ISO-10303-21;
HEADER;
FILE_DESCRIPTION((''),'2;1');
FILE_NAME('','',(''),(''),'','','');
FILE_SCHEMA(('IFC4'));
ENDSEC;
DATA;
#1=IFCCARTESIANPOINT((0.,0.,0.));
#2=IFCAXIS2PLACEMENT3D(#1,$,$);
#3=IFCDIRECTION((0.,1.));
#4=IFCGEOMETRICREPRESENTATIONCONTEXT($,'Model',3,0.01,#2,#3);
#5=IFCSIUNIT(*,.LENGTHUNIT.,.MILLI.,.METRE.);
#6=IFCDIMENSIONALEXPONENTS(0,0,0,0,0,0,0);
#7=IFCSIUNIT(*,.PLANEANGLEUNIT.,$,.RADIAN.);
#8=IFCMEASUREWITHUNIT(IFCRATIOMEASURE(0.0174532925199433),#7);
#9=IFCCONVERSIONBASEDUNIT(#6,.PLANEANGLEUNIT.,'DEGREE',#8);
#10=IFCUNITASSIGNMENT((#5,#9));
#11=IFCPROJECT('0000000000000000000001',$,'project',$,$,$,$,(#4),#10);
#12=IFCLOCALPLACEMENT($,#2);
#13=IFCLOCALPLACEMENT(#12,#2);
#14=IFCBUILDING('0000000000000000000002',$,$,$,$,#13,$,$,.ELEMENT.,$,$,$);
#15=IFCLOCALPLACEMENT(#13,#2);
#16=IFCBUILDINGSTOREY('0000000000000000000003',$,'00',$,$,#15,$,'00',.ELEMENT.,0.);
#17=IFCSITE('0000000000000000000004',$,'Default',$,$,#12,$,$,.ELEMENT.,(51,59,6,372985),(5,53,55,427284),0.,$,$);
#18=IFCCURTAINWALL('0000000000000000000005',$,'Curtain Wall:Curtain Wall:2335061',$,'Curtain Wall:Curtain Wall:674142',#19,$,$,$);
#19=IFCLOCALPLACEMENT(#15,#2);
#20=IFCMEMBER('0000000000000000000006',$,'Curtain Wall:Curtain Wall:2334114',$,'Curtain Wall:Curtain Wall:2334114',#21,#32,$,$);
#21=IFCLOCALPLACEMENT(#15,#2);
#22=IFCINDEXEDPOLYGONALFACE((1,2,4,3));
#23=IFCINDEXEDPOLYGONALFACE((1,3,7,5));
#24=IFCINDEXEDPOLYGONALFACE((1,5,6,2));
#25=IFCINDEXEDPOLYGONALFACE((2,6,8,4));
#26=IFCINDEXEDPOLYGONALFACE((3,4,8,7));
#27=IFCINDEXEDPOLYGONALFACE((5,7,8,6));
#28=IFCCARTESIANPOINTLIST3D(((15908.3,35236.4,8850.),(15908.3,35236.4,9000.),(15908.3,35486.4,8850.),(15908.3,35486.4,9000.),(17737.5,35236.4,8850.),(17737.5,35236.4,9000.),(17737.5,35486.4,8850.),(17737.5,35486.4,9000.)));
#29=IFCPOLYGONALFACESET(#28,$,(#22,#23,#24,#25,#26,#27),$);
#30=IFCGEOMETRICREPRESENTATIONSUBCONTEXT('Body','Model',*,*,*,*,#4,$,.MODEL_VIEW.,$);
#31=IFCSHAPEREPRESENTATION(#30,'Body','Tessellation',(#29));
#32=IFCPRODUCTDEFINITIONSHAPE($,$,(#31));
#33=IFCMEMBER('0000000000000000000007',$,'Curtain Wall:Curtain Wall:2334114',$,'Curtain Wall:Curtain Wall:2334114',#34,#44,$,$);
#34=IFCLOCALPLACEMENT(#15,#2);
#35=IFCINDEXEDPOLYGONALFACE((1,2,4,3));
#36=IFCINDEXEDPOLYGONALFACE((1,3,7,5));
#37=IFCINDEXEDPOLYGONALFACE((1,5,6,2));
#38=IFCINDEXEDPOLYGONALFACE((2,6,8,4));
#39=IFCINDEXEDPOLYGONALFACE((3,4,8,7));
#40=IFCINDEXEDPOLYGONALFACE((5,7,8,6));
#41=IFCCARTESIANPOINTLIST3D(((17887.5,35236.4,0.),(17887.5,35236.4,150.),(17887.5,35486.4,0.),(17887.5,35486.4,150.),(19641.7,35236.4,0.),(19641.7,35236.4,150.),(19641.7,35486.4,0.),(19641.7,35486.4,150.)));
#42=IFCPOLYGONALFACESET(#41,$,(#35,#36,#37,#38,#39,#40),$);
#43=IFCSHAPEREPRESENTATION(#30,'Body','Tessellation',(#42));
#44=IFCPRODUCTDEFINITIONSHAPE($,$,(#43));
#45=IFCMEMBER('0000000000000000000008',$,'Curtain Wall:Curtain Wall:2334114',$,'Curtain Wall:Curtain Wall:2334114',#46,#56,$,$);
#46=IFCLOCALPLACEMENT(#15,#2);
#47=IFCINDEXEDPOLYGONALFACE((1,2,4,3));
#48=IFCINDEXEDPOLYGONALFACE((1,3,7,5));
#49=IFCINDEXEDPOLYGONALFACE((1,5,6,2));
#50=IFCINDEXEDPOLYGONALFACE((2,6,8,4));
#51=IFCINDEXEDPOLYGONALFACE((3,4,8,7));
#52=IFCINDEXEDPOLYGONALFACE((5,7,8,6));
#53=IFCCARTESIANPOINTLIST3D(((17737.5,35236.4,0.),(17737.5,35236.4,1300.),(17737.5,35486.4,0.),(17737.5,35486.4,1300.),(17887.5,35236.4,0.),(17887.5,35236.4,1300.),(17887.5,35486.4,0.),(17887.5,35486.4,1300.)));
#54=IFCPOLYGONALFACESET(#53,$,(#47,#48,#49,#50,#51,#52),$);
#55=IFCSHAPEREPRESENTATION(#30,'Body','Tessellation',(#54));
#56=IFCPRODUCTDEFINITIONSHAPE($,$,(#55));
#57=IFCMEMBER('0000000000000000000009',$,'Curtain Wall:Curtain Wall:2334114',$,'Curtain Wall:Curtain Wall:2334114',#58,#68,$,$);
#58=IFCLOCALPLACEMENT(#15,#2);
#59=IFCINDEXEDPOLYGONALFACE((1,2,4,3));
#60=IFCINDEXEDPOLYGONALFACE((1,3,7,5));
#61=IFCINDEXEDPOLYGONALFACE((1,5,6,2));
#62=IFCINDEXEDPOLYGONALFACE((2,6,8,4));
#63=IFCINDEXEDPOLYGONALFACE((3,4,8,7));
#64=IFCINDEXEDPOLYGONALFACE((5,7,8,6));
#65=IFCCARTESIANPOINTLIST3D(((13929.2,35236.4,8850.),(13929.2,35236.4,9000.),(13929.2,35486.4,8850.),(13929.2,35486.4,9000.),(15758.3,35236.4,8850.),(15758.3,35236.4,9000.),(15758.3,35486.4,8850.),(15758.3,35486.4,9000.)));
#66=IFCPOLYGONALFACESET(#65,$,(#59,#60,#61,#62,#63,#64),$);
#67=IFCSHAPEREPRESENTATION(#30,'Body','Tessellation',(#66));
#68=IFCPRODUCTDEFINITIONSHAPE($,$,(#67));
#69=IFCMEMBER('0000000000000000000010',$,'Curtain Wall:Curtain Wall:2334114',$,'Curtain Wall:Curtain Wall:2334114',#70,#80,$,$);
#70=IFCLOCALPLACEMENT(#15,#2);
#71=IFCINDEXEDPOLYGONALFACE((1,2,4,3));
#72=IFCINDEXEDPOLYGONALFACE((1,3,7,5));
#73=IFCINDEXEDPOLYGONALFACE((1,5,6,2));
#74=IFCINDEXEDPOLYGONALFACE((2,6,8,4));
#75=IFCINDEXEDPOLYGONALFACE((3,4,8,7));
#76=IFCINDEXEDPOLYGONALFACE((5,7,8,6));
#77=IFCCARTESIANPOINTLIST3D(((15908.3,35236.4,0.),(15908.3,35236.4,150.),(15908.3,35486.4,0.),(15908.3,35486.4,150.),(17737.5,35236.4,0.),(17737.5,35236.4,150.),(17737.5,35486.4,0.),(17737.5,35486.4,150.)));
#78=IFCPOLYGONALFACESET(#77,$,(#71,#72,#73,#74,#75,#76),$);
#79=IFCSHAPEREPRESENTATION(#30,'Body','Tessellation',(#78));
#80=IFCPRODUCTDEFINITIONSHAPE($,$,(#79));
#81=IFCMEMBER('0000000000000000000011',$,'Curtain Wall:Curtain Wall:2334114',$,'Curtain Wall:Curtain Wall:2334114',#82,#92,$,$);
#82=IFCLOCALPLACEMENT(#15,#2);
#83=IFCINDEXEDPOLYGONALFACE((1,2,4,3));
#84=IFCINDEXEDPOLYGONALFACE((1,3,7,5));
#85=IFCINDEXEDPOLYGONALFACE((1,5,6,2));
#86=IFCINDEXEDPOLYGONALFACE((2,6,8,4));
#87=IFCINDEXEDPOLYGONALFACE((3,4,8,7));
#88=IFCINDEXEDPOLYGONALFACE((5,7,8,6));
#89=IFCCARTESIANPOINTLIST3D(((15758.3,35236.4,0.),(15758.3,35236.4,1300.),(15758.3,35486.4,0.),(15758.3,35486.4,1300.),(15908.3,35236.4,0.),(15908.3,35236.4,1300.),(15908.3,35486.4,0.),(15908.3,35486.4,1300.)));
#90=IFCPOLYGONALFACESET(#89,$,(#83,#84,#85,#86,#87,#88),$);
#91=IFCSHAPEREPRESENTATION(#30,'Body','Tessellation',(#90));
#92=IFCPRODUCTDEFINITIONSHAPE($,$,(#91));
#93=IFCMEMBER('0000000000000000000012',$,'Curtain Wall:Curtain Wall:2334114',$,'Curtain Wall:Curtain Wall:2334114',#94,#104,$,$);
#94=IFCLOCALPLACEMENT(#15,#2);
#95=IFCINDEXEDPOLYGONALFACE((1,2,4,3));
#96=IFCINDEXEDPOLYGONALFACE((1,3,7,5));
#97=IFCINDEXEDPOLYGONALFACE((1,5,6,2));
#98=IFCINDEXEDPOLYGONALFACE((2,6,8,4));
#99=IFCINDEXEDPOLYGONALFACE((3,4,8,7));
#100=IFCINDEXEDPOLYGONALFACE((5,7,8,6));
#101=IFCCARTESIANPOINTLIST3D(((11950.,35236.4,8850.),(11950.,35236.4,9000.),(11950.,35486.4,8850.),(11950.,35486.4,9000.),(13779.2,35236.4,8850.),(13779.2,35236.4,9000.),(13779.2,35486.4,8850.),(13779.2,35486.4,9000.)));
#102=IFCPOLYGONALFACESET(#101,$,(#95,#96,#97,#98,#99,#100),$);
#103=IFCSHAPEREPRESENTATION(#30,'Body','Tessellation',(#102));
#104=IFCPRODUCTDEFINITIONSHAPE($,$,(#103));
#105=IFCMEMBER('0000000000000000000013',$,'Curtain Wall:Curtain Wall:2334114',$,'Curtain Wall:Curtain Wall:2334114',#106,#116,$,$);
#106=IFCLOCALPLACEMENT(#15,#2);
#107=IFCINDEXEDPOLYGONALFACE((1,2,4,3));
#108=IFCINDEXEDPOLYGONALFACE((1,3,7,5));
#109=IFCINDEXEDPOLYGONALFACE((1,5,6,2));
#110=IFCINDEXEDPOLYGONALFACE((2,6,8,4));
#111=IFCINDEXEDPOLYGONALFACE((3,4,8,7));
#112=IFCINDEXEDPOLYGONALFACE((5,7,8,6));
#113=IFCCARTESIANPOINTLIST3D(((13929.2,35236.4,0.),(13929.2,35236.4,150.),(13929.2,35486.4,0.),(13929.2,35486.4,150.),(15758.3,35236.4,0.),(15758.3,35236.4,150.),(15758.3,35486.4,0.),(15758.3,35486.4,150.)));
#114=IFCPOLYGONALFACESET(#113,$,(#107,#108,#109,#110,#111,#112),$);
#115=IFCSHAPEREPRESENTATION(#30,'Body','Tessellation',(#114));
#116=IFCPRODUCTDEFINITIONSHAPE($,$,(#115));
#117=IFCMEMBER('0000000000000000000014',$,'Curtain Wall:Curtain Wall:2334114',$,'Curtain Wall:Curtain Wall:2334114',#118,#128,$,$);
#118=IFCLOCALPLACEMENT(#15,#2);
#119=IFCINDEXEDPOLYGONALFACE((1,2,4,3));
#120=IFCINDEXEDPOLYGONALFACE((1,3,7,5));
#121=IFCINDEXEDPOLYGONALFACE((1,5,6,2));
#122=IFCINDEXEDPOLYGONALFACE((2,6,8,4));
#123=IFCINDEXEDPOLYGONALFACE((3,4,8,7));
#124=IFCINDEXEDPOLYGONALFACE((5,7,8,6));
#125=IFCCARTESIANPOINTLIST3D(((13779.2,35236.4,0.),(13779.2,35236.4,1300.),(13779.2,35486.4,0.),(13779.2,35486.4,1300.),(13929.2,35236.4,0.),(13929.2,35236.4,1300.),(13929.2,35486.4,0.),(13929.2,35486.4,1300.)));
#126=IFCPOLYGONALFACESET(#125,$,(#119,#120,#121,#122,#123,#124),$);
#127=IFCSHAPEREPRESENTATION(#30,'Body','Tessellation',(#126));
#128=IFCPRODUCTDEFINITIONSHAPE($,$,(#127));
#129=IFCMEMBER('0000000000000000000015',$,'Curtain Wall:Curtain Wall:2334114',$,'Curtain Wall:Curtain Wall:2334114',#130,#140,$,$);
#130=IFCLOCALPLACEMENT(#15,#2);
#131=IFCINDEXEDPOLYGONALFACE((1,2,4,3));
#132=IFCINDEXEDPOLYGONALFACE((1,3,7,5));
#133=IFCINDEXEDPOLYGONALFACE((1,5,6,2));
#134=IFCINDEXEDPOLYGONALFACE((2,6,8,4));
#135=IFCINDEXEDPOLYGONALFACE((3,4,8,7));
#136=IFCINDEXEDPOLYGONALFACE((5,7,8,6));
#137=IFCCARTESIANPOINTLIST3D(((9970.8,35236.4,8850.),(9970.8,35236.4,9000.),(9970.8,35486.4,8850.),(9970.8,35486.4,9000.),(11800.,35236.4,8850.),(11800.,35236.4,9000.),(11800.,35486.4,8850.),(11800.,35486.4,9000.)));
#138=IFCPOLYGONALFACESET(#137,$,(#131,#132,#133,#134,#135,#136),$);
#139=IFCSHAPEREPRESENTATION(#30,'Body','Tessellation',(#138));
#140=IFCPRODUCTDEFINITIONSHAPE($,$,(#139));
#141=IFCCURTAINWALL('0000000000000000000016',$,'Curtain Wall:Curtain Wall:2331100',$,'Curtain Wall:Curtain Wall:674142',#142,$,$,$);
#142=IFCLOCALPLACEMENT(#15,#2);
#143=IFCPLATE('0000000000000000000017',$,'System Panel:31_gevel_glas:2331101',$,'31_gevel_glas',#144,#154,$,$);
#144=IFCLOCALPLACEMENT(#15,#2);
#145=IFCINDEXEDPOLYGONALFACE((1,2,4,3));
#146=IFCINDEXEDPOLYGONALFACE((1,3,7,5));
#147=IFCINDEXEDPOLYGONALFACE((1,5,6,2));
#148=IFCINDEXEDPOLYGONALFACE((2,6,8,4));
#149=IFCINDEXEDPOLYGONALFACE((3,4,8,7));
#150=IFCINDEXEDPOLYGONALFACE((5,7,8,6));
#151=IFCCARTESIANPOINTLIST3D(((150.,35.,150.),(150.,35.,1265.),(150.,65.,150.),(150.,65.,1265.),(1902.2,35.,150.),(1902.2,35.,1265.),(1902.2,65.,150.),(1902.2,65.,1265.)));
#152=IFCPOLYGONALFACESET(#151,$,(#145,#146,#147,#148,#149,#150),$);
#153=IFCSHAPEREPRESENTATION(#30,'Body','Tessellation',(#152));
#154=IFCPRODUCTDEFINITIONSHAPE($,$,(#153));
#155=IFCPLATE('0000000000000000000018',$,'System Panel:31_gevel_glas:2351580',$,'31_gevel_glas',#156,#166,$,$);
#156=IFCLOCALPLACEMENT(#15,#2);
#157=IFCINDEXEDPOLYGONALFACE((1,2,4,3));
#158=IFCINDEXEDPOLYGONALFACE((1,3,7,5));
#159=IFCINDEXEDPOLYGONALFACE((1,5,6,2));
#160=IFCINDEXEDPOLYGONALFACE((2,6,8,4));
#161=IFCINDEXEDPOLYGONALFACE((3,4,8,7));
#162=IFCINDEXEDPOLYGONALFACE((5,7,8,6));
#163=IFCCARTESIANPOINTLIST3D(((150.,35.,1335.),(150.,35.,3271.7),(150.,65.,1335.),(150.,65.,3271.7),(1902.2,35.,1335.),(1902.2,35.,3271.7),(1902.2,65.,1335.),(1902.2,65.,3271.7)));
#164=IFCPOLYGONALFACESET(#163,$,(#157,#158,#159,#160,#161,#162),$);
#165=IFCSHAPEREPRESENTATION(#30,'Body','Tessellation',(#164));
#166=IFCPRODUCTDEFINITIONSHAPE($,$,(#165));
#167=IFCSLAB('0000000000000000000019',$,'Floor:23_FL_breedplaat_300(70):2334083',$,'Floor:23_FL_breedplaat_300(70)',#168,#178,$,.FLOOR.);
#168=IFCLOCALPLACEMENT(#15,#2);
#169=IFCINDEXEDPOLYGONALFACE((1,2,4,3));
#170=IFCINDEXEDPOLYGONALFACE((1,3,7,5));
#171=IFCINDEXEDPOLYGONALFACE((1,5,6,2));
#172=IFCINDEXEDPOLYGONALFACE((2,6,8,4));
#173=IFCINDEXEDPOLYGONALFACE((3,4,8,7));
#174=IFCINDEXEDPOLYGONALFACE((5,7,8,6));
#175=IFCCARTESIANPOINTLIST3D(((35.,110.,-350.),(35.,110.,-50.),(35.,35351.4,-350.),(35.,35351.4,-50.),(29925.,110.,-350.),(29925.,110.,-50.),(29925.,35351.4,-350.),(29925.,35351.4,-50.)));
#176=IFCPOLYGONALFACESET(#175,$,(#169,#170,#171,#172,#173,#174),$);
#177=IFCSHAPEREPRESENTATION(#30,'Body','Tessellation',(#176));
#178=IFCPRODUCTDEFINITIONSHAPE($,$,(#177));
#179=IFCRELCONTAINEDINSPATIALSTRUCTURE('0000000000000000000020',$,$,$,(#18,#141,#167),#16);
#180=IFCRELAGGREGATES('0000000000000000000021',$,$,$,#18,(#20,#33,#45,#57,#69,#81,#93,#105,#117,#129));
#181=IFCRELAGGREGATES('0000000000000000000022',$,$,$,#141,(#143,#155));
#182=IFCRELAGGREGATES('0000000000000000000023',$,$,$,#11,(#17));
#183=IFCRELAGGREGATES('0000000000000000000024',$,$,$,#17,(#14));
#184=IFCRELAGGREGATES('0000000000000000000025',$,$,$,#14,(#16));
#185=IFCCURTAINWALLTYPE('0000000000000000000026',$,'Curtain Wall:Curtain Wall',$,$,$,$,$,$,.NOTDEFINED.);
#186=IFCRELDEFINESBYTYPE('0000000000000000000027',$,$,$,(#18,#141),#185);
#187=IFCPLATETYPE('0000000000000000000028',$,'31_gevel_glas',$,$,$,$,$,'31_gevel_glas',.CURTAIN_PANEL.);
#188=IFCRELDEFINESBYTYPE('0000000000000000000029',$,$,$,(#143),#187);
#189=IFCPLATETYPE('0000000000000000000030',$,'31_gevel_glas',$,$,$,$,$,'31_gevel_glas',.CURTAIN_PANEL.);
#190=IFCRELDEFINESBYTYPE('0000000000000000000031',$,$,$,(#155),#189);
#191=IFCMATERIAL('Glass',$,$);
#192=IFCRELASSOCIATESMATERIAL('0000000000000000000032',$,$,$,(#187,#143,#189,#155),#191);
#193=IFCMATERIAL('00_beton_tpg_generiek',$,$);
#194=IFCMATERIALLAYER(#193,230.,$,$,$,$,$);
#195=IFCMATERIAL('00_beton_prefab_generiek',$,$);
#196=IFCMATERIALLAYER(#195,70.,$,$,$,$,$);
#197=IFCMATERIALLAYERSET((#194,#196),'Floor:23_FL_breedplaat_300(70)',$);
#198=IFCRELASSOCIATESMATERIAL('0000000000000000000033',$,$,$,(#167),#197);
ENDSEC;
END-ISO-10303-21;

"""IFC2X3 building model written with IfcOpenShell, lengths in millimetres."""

from ifc_helpers import new_model, entity, si_unit, converted_unit, direction, frame, frame_2d, origin, origin_2d_with_axis, place, context, subcontext, project, spatial, rectangle, extrude, source, transform, mapped, material, layer, layer_set, layer_usage, type_object, type_shapes, element, aggregate, save


model = new_model("IFC2X3")

# Units and contexts
model_context = context("Model", 3, precision=0.01, world=origin(), true_north=direction((0.0, 1.0)))
body_context = subcontext(model_context, "Body", "Model", "MODEL_VIEW")
ifc_project = project(units=[si_unit("LENGTHUNIT", "METRE", prefix="MILLI"), converted_unit("PLANEANGLEUNIT", "DEGREE", entity("IfcRatioMeasure", 0.0174532925199433), si_unit("PLANEANGLEUNIT", "RADIAN"), dimensions=[0, 0, 0, 0, 0, 0, 0])], contexts=[model_context])

# Site, building, storey
site_placement = place(None, origin())
site = spatial("IfcSite", under=ifc_project, at=site_placement, Name="Default", CompositionType="ELEMENT", RefLatitude=(51, 59, 6, 372985), RefLongitude=(5, 53, 55, 427284), RefElevation=0.0)
building_placement = place(site_placement, origin())
building = spatial("IfcBuilding", under=site, at=building_placement, CompositionType="ELEMENT")
storey_placement = place(building_placement, origin())
storey = spatial("IfcBuildingStorey", under=building, at=storey_placement, Name="00", LongName="00", CompositionType="ELEMENT", Elevation=0.0)

# Shared definitions
ifc_material_1 = material(Name="00_beton_tpg_generiek")

# Curtain wall, members
curtain_wall_type = type_object("IfcCurtainWallType", Name="Curtain Wall:Curtain Wall", PredefinedType="NOTDEFINED")
curtain_wall_1_placement = place(storey_placement, origin())
curtain_wall_1 = element("IfcCurtainWall", 1, at=curtain_wall_1_placement, inside=storey, type_object=curtain_wall_type, Name="Curtain Wall:Curtain Wall:2335061", ObjectType="Curtain Wall:Curtain Wall:674142")
member_1_placement = place(curtain_wall_1_placement, origin())
member_1 = element("IfcMember", 2, at=member_1_placement, Name="Curtain Wall:Curtain Wall:2334114", ObjectType="Curtain Wall:Curtain Wall:2334114", context=body_context, shape_type="SweptSolid", body=[
    extrude(rectangle(XDim=150.0, YDim=250.0, at=frame_2d((0.0, 0.0), x_axis=(1.0, 0.0))), frame((17737.5, 35361.4, 8925.0), z_axis=(-1.0, 0.0, 0.0), x_axis=(0.0, 0.0, -1.0)), (0.0, 0.0, 1.0), 1829.2),
])
member_2_placement = place(curtain_wall_1_placement, origin())
member_2 = element("IfcMember", 3, at=member_2_placement, Name="Curtain Wall:Curtain Wall:2334114", ObjectType="Curtain Wall:Curtain Wall:2334114", context=body_context, shape_type="SweptSolid", body=[
    extrude(rectangle(XDim=150.0, YDim=250.0, at=frame_2d((0.0, 0.0), x_axis=(1.0, 0.0))), frame((17887.5, 35361.4, 75.0), z_axis=(1.0, 0.0, 0.0), x_axis=(0.0, 0.0, -1.0)), (0.0, 0.0, 1.0), 1754.2),
])
member_3_placement = place(curtain_wall_1_placement, origin())
member_3 = element("IfcMember", 4, at=member_3_placement, Name="Curtain Wall:Curtain Wall:2334114", ObjectType="Curtain Wall:Curtain Wall:2334114", context=body_context, shape_type="SweptSolid", body=[
    extrude(rectangle(XDim=150.0, YDim=250.0, at=frame_2d((0.0, 0.0), x_axis=(1.0, 0.0))), frame((17812.5, 35361.4, 0.0), z_axis=(0.0, 0.0, 1.0), x_axis=(-1.0, 0.0, 0.0)), (0.0, 0.0, 1.0), 1300.0),
])
member_4_placement = place(curtain_wall_1_placement, origin())
member_4 = element("IfcMember", 5, at=member_4_placement, Name="Curtain Wall:Curtain Wall:2334114", ObjectType="Curtain Wall:Curtain Wall:2334114", context=body_context, shape_type="SweptSolid", body=[
    extrude(rectangle(XDim=150.0, YDim=250.0, at=frame_2d((0.0, 0.0), x_axis=(1.0, 0.0))), frame((15758.3, 35361.4, 8925.0), z_axis=(-1.0, 0.0, 0.0), x_axis=(0.0, 0.0, -1.0)), (0.0, 0.0, 1.0), 1829.2),
])
member_5_placement = place(curtain_wall_1_placement, origin())
member_5 = element("IfcMember", 6, at=member_5_placement, Name="Curtain Wall:Curtain Wall:2334114", ObjectType="Curtain Wall:Curtain Wall:2334114", context=body_context, shape_type="SweptSolid", body=[
    extrude(rectangle(XDim=150.0, YDim=250.0, at=frame_2d((0.0, 0.0), x_axis=(1.0, 0.0))), frame((15908.3, 35361.4, 75.0), z_axis=(1.0, 0.0, 0.0), x_axis=(0.0, 0.0, -1.0)), (0.0, 0.0, 1.0), 1829.2),
])
member_6_placement = place(curtain_wall_1_placement, origin())
member_6 = element("IfcMember", 7, at=member_6_placement, Name="Curtain Wall:Curtain Wall:2334114", ObjectType="Curtain Wall:Curtain Wall:2334114", context=body_context, shape_type="SweptSolid", body=[
    extrude(rectangle(XDim=150.0, YDim=250.0, at=frame_2d((0.0, 0.0), x_axis=(1.0, 0.0))), frame((15833.3, 35361.4, 0.0), z_axis=(0.0, 0.0, 1.0), x_axis=(-1.0, 0.0, 0.0)), (0.0, 0.0, 1.0), 1300.0),
])
member_7_placement = place(curtain_wall_1_placement, origin())
member_7 = element("IfcMember", 8, at=member_7_placement, Name="Curtain Wall:Curtain Wall:2334114", ObjectType="Curtain Wall:Curtain Wall:2334114", context=body_context, shape_type="SweptSolid", body=[
    extrude(rectangle(XDim=150.0, YDim=250.0, at=frame_2d((0.0, 0.0), x_axis=(1.0, 0.0))), frame((13779.2, 35361.4, 8925.0), z_axis=(-1.0, 0.0, 0.0), x_axis=(0.0, 0.0, -1.0)), (0.0, 0.0, 1.0), 1829.2),
])
member_8_placement = place(curtain_wall_1_placement, origin())
member_8 = element("IfcMember", 9, at=member_8_placement, Name="Curtain Wall:Curtain Wall:2334114", ObjectType="Curtain Wall:Curtain Wall:2334114", context=body_context, shape_type="SweptSolid", body=[
    extrude(rectangle(XDim=150.0, YDim=250.0, at=frame_2d((0.0, 0.0), x_axis=(1.0, 0.0))), frame((13929.2, 35361.4, 75.0), z_axis=(1.0, 0.0, 0.0), x_axis=(0.0, 0.0, -1.0)), (0.0, 0.0, 1.0), 1829.2),
])
member_9_placement = place(curtain_wall_1_placement, origin())
member_9 = element("IfcMember", 10, at=member_9_placement, Name="Curtain Wall:Curtain Wall:2334114", ObjectType="Curtain Wall:Curtain Wall:2334114", context=body_context, shape_type="SweptSolid", body=[
    extrude(rectangle(XDim=150.0, YDim=250.0, at=frame_2d((0.0, 0.0), x_axis=(1.0, 0.0))), frame((13854.2, 35361.4, 0.0), z_axis=(0.0, 0.0, 1.0), x_axis=(-1.0, 0.0, 0.0)), (0.0, 0.0, 1.0), 1300.0),
])
member_10_placement = place(curtain_wall_1_placement, origin())
member_10 = element("IfcMember", 11, at=member_10_placement, Name="Curtain Wall:Curtain Wall:2334114", ObjectType="Curtain Wall:Curtain Wall:2334114", context=body_context, shape_type="SweptSolid", body=[
    extrude(rectangle(XDim=150.0, YDim=250.0, at=frame_2d((0.0, 0.0), x_axis=(1.0, 0.0))), frame((11800.0, 35361.4, 8925.0), z_axis=(-1.0, 0.0, 0.0), x_axis=(0.0, 0.0, -1.0)), (0.0, 0.0, 1.0), 1829.2),
])
aggregate(curtain_wall_1, [member_1, member_2, member_3, member_4, member_5, member_6, member_7, member_8, member_9, member_10])

# Curtain wall, plates
curtain_wall_2_placement = place(storey_placement, origin())
curtain_wall_2 = element("IfcCurtainWall", 12, at=curtain_wall_2_placement, inside=storey, type_object=curtain_wall_type, Name="Curtain Wall:Curtain Wall:2331100", ObjectType="Curtain Wall:Curtain Wall:674142")
ifc_material_2 = material(Name="Glass")
plate_type_1 = type_object("IfcPlateType", Name="31_gevel_glas", ElementType="31_gevel_glas", PredefinedType="CURTAIN_PANEL", material=ifc_material_2)
shared_shape_1 = source(origin(), body_context, "Body", "SweptSolid", [
    extrude(rectangle(XDim=30.0, YDim=1752.2, at=origin_2d_with_axis()), frame((0.0, 50.0, 0.0), z_axis=(0.0, 0.0, 1.0), x_axis=(0.0, 1.0, 0.0)), (0.0, 0.0, 1.0), 1115.0),
])
type_shapes(plate_type_1, [shared_shape_1])
plate_1_placement = place(curtain_wall_2_placement, frame((1026.1, 0.0, 150.0)))
plate_1 = element("IfcPlate", 13, at=plate_1_placement, type_object=plate_type_1, material=ifc_material_2, Name="System Panel:31_gevel_glas:2331101", ObjectType="31_gevel_glas", context=body_context, shape_type="MappedRepresentation", body=[
    mapped(shared_shape_1, transform((0.0, 0.0, 0.0), scale=1.0)),
])
plate_type_2 = type_object("IfcPlateType", Name="31_gevel_glas", ElementType="31_gevel_glas", PredefinedType="CURTAIN_PANEL", material=ifc_material_2)
shared_shape_2 = source(origin(), body_context, "Body", "SweptSolid", [
    extrude(rectangle(XDim=30.0, YDim=1752.2, at=origin_2d_with_axis()), frame((0.0, 50.0, 0.0), z_axis=(0.0, 0.0, 1.0), x_axis=(0.0, 1.0, 0.0)), (0.0, 0.0, 1.0), 1936.7),
])
type_shapes(plate_type_2, [shared_shape_2])
plate_2_placement = place(curtain_wall_2_placement, frame((1026.1, 0.0, 1335.0)))
plate_2 = element("IfcPlate", 14, at=plate_2_placement, type_object=plate_type_2, material=ifc_material_2, Name="System Panel:31_gevel_glas:2351580", ObjectType="31_gevel_glas", context=body_context, shape_type="MappedRepresentation", body=[
    mapped(shared_shape_2, transform((0.0, 0.0, 0.0), scale=1.0)),
])
aggregate(curtain_wall_2, [plate_1, plate_2])

# Slab
ifc_layer_1 = layer(ifc_material_1, 230.0)
ifc_material_3 = material(Name="00_beton_prefab_generiek")
ifc_layer_2 = layer(ifc_material_3, 70.0)
ifc_layer_set = layer_set([ifc_layer_1, ifc_layer_2], Name="Floor:23_FL_breedplaat_300(70)")
ifc_layer_usage = layer_usage(ifc_layer_set, "AXIS3", "POSITIVE", 0.0)
slab_placement = place(storey_placement, origin())
element("IfcSlab", 15, at=slab_placement, inside=storey, material=ifc_layer_usage, Name="Floor:23_FL_breedplaat_300(70):2334083", ObjectType="Floor:23_FL_breedplaat_300(70)", PredefinedType="FLOOR", context=body_context, shape_type="SweptSolid", body=[
    extrude(rectangle(XDim=35241.4, YDim=29890.0, at=origin_2d_with_axis()), frame((14980.0, 17730.7, -50.0), z_axis=(0.0, 0.0, -1.0), x_axis=(0.0, 1.0, 0.0)), (0.0, 0.0, 1.0), 300.0),
])

save(model, "model.ifc")
